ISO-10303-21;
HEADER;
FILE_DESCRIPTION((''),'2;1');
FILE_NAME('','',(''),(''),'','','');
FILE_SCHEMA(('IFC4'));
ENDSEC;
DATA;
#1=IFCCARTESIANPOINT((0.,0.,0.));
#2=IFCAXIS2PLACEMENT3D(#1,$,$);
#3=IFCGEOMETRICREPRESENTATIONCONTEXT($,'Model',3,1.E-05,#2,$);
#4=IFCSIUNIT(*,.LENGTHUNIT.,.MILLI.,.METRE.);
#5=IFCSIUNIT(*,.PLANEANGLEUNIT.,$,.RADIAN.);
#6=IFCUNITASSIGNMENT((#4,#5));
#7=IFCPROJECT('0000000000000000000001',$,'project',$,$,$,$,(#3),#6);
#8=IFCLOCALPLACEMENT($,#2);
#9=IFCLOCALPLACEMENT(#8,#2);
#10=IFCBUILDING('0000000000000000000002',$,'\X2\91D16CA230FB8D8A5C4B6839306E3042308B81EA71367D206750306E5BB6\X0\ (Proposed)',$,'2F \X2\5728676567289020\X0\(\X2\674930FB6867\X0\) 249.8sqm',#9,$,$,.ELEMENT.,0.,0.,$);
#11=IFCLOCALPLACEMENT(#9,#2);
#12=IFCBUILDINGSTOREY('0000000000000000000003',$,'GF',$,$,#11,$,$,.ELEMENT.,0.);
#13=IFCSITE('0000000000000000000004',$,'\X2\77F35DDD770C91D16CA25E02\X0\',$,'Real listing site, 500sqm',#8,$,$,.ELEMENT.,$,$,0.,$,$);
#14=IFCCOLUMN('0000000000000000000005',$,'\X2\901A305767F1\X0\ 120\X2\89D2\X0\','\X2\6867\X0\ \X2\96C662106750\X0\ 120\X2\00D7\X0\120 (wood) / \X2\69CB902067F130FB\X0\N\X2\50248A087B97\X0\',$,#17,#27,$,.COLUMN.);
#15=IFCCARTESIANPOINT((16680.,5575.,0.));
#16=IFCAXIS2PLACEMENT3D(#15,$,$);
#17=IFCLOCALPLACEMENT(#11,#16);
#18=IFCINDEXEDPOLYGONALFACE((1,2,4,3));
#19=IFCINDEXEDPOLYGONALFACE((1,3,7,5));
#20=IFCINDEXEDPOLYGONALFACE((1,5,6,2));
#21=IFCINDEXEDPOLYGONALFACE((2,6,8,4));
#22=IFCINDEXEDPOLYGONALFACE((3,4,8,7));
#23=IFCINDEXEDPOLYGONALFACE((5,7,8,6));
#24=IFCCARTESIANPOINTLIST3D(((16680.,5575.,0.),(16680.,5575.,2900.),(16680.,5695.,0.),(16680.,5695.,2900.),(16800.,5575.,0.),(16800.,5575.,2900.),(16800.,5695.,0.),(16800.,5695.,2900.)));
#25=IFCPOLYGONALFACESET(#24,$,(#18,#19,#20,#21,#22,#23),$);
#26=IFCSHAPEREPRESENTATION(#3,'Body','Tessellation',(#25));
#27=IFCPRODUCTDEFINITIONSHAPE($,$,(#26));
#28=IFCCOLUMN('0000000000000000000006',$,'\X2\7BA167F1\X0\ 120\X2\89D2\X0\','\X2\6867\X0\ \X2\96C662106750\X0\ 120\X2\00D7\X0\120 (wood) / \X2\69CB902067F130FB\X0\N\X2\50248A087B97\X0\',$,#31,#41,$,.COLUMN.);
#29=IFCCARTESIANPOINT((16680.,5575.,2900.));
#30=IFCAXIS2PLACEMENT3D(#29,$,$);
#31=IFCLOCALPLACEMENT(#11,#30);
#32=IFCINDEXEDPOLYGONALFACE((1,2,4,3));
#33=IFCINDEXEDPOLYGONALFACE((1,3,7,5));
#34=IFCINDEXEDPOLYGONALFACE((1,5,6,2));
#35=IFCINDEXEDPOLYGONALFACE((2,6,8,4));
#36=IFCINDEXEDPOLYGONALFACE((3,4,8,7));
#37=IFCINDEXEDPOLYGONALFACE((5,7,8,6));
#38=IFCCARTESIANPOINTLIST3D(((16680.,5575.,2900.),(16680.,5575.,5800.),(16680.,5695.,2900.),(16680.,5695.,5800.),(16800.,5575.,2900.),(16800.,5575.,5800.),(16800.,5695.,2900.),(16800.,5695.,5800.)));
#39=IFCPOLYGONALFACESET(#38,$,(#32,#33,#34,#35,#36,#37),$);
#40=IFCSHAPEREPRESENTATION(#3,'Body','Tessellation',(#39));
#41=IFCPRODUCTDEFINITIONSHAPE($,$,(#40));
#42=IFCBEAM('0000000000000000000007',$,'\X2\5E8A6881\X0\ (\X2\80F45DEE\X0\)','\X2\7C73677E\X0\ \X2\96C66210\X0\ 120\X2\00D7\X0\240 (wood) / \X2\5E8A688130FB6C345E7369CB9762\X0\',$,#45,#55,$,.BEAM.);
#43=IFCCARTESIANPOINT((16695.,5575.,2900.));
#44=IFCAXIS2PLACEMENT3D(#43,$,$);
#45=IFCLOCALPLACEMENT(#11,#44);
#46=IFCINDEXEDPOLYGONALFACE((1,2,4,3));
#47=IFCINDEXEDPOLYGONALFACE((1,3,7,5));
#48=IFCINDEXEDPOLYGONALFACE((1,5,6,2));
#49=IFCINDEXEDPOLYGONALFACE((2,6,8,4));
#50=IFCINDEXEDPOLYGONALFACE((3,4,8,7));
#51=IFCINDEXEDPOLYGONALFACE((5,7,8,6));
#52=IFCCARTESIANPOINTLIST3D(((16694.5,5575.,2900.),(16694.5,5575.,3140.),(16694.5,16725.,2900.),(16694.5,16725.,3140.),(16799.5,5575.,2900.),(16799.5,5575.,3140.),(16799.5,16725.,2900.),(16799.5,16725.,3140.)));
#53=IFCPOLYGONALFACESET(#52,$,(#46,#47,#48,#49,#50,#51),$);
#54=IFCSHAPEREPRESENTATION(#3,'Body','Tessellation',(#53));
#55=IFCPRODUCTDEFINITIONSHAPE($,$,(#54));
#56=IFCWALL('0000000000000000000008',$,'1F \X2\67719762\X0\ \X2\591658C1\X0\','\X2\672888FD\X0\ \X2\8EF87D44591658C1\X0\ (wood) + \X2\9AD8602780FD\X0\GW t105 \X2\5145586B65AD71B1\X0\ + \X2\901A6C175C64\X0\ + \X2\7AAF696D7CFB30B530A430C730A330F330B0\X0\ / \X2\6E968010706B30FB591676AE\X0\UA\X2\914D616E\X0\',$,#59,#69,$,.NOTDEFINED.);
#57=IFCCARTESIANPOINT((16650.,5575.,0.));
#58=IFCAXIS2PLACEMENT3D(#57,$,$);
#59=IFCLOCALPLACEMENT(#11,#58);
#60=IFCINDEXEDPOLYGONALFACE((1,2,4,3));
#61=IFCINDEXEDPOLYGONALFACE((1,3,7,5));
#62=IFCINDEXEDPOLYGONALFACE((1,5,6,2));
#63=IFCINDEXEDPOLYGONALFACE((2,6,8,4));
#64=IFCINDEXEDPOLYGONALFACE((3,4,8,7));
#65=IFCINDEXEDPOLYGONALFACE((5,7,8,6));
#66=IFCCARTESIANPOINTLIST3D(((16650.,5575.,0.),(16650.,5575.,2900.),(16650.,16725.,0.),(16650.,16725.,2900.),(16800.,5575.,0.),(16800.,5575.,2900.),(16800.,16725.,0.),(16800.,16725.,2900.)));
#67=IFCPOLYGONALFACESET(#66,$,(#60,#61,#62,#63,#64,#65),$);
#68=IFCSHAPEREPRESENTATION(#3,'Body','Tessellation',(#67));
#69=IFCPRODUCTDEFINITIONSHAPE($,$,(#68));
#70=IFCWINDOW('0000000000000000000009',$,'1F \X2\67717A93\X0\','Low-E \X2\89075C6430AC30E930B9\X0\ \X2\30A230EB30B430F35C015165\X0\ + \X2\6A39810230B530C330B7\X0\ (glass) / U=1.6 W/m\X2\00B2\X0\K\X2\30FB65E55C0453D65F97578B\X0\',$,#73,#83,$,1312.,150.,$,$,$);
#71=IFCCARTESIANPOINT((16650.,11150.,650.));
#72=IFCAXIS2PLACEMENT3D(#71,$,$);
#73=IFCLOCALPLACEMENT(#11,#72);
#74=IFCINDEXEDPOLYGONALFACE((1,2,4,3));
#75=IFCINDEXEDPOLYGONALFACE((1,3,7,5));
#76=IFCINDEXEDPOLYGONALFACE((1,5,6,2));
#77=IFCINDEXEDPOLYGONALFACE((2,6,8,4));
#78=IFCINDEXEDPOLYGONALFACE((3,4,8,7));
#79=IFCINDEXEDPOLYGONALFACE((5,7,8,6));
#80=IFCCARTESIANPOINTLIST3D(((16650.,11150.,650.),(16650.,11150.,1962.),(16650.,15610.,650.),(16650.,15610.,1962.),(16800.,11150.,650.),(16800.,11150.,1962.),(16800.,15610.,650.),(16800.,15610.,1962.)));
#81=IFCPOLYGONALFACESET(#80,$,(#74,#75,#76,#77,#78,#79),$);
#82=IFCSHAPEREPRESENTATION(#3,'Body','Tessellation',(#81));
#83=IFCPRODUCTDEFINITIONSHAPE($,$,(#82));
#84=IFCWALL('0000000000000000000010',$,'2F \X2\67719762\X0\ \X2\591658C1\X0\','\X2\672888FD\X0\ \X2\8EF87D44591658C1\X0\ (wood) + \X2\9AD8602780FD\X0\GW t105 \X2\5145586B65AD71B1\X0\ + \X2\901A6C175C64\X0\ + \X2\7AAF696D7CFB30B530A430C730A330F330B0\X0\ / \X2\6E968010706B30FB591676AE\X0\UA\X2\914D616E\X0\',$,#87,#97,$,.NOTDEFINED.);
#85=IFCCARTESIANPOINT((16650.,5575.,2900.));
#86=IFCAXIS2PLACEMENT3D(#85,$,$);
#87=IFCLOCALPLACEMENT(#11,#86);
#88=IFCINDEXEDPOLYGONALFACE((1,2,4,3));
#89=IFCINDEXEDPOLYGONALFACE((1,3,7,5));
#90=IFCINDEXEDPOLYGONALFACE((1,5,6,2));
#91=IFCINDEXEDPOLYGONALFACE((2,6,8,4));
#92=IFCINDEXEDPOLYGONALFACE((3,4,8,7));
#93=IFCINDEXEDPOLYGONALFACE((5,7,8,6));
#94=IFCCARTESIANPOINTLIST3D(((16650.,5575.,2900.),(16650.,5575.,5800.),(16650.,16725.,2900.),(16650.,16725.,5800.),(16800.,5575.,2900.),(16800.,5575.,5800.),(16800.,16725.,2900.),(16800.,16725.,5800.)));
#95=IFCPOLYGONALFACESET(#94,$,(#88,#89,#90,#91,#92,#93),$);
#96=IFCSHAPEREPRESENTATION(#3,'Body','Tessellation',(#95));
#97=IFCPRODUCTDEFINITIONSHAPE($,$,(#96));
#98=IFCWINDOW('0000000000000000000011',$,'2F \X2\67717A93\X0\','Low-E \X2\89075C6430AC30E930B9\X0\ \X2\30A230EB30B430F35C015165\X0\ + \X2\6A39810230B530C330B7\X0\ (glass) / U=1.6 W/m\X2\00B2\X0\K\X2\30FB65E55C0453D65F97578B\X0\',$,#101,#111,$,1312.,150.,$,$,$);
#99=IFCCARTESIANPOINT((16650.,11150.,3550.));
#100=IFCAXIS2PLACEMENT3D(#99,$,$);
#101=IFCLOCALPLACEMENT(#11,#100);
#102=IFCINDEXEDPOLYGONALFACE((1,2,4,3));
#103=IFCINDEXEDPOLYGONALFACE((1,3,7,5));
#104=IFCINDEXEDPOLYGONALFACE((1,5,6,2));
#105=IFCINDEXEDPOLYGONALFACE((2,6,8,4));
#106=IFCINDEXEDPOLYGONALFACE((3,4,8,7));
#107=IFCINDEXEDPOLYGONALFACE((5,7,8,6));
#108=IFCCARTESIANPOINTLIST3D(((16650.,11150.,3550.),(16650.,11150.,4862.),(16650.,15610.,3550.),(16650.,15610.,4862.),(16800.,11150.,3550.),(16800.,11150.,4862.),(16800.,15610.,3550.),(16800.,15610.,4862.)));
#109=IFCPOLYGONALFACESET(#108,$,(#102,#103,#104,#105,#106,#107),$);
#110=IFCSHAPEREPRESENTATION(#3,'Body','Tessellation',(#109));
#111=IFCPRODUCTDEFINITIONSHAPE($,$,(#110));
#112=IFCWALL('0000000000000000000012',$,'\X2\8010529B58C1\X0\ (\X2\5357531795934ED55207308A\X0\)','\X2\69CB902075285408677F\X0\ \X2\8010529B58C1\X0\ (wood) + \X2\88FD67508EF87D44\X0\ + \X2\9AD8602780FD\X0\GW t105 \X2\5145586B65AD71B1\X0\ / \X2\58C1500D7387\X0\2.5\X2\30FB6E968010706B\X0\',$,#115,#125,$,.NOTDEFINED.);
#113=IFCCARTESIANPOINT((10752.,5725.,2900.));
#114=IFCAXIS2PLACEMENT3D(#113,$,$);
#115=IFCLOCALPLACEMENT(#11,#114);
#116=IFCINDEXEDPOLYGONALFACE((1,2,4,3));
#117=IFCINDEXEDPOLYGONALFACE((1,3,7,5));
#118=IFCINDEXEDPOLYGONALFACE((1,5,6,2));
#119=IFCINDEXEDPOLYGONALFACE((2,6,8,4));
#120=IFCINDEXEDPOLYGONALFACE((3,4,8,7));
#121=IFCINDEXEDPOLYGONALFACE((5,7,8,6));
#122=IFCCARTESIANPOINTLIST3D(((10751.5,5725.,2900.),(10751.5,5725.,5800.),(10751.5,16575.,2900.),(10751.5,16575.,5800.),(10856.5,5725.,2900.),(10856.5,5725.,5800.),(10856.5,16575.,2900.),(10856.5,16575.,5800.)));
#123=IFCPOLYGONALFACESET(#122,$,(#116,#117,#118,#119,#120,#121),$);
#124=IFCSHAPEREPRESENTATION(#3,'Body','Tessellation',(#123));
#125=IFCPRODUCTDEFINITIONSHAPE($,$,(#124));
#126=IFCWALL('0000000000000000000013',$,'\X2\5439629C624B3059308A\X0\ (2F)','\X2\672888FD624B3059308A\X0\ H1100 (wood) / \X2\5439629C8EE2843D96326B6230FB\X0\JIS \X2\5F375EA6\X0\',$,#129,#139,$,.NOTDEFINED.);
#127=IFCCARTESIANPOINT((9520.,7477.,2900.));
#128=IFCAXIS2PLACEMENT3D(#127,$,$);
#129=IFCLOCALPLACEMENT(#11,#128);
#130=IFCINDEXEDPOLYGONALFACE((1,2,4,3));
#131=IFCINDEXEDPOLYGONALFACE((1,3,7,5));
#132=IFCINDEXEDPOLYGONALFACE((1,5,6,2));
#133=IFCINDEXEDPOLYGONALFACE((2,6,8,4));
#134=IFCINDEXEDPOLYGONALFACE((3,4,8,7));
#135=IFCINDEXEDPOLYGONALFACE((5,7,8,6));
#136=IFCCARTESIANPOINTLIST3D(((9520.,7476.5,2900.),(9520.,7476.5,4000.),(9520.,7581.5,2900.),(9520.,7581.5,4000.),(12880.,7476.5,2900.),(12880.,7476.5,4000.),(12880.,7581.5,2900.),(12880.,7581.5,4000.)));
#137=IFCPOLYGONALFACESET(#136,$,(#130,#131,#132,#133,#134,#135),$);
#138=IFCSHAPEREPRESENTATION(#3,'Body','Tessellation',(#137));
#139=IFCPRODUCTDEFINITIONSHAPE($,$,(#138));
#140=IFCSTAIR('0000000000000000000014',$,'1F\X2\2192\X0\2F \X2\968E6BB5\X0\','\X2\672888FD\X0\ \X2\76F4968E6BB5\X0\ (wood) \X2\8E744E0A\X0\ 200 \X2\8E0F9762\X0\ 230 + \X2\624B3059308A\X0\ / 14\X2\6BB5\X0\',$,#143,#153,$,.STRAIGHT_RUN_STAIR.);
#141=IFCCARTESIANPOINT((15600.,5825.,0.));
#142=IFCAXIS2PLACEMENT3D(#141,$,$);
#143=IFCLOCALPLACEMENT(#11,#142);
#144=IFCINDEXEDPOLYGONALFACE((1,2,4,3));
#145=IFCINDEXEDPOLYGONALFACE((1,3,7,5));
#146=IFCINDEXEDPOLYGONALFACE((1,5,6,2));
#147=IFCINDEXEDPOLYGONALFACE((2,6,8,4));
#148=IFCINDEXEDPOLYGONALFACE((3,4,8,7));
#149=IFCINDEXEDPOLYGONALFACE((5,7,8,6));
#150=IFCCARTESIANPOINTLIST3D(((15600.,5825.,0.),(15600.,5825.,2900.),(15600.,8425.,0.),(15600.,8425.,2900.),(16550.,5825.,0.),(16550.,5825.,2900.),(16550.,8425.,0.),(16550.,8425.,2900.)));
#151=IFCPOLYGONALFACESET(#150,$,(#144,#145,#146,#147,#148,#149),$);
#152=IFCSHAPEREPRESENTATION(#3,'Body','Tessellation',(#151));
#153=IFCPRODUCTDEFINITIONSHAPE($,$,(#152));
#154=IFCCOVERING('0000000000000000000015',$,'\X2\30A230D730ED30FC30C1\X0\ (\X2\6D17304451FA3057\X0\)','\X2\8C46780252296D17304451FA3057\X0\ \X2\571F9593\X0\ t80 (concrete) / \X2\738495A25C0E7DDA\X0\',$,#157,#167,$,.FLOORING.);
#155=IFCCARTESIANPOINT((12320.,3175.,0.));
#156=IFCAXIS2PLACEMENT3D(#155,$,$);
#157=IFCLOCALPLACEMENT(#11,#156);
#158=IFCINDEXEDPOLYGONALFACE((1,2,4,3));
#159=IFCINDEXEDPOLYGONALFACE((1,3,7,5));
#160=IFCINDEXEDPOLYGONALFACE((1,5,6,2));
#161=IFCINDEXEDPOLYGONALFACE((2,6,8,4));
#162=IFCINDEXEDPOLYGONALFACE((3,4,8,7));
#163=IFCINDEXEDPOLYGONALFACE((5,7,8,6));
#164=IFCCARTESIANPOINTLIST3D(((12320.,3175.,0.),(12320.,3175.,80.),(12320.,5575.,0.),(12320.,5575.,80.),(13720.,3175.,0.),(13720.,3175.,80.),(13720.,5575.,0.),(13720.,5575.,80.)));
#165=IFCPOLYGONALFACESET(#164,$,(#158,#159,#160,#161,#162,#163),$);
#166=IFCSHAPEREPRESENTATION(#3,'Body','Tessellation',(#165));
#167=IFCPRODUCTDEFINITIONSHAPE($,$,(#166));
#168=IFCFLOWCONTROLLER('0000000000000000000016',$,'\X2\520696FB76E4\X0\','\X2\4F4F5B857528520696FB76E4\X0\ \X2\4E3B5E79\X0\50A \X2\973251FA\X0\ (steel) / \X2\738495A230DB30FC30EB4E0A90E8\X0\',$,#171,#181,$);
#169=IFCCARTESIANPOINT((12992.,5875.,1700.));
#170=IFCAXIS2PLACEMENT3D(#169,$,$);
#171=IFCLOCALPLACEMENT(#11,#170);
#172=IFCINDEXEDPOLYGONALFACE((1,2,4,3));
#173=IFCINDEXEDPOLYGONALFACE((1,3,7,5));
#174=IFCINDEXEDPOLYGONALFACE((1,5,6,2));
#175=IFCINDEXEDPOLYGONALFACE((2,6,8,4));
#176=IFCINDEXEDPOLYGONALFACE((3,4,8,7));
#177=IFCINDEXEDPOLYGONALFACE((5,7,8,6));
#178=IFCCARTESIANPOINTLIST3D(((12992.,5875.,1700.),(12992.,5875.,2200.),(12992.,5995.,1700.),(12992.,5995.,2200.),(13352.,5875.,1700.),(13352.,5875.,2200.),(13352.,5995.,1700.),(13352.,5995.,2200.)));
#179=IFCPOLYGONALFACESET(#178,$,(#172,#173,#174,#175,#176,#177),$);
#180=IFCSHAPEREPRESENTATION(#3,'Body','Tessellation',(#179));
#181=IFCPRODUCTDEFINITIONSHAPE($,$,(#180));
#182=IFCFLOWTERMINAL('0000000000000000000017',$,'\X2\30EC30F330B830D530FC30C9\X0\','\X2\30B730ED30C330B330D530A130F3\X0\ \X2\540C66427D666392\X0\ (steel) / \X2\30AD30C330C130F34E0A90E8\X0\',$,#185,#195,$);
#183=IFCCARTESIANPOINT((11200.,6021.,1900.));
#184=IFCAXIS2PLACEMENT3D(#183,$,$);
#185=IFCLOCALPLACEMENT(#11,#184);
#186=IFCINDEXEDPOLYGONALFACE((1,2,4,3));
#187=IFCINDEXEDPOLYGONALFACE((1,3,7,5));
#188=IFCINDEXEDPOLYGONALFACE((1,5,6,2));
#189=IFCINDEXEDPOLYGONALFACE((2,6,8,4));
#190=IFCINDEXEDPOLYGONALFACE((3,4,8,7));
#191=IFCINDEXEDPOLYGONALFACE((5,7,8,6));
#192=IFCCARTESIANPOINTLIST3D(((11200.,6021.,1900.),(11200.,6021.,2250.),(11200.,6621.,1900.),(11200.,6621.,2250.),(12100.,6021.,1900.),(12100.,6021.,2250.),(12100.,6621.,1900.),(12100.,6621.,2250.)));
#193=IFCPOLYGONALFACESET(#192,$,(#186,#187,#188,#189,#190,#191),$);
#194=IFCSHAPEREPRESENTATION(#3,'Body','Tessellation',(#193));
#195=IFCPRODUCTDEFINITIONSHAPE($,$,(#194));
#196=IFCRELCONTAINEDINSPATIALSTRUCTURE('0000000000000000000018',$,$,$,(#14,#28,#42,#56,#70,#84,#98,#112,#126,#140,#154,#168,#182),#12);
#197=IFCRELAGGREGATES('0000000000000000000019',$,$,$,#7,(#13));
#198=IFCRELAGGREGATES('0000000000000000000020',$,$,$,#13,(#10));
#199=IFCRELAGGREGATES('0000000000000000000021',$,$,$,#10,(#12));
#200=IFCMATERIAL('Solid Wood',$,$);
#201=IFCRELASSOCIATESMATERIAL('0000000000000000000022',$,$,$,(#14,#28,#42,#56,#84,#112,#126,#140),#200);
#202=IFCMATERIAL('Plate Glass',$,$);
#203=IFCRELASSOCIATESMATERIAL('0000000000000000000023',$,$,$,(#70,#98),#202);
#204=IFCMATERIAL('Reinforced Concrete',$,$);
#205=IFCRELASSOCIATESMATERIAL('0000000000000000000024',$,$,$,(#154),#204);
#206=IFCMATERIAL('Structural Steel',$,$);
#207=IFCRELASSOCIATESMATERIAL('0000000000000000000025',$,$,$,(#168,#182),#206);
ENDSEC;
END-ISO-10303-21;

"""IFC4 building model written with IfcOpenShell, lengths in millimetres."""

from ifc_helpers import new_model, si_unit, frame, frame_2d, origin, place, context, project, spatial, rectangle, extrude, material, element, fill, save


model = new_model("IFC4")

# Units and contexts
model_context = context("Model", 3, precision=1e-05, world=origin())
ifc_project = project(units=[si_unit("LENGTHUNIT", "METRE", prefix="MILLI"), si_unit("PLANEANGLEUNIT", "RADIAN")], contexts=[model_context])

# Site, building, storey
site_placement = place(None, origin())
site = spatial("IfcSite", under=ifc_project, at=site_placement, Name="石川県金沢市", ObjectType="Real listing site, 500sqm", CompositionType="ELEMENT", RefElevation=0.0)
building_placement = place(site_placement, origin())
building = spatial("IfcBuilding", under=site, at=building_placement, Name="金沢・越屋根のある自然素材の家 (Proposed)", ObjectType="2F 在来木造(杉・桧) 249.8sqm", CompositionType="ELEMENT", ElevationOfRefHeight=0.0, ElevationOfTerrain=0.0)
storey_placement = place(building_placement, origin())
storey = spatial("IfcBuildingStorey", under=building, at=storey_placement, Name="GF", CompositionType="ELEMENT", Elevation=0.0)

# Columns
ifc_material_1 = material(Name="Solid Wood")
column_1_placement = place(storey_placement, frame((16680.0, 5575.0, 0.0)))
element("IfcColumn", 1, at=column_1_placement, inside=storey, material=ifc_material_1, Name="通し柱 120角", Description="桧 集成材 120×120 (wood) / 構造柱・N値計算", PredefinedType="COLUMN", context=model_context, shape_type="SweptSolid", body=[
    extrude(rectangle(XDim=120.0, YDim=120.0, at=frame_2d((60.0, 60.0))), frame((16680.0, 5575.0, 0.0)), (0.0, 0.0, 1.0), 2900.0),
])
column_2_placement = place(storey_placement, frame((16680.0, 5575.0, 2900.0)))
element("IfcColumn", 2, at=column_2_placement, inside=storey, material=ifc_material_1, Name="管柱 120角", Description="桧 集成材 120×120 (wood) / 構造柱・N値計算", PredefinedType="COLUMN", context=model_context, shape_type="SweptSolid", body=[
    extrude(rectangle(XDim=120.0, YDim=120.0, at=frame_2d((60.0, 60.0))), frame((16680.0, 5575.0, 2900.0)), (0.0, 0.0, 1.0), 2900.0),
])

# Beam
beam_1_placement = place(storey_placement, frame((16695.0, 5575.0, 2900.0)))
element("IfcBeam", 3, at=beam_1_placement, inside=storey, material=ifc_material_1, Name="床梁 (胴差)", Description="米松 集成 120×240 (wood) / 床梁・水平構面", PredefinedType="BEAM", context=model_context, shape_type="SweptSolid", body=[
    extrude(rectangle(XDim=105.0, YDim=11150.0, at=frame_2d((52.0, 5575.0))), frame((16695.0, 5575.0, 2900.0)), (0.0, 0.0, 1.0), 240.0),
])

# Wall, opening, window
wall_1_placement = place(storey_placement, frame((16650.0, 5575.0, 0.0)))
wall_1 = element("IfcWall", 4, at=wall_1_placement, inside=storey, material=ifc_material_1, Name="1F 東面 外壁", Description="木製 軸組外壁 (wood) + 高性能GW t105 充填断熱 + 通気層 + 窯業系サイディング / 準耐火・外皮UA配慮", PredefinedType="NOTDEFINED", context=model_context, shape_type="SweptSolid", body=[
    extrude(rectangle(XDim=150.0, YDim=11150.0, at=frame_2d((75.0, 5575.0))), frame((16650.0, 5575.0, 0.0)), (0.0, 0.0, 1.0), 2900.0),
])
opening_1_placement = place(storey_placement, frame((16650.0, 11150.0, 650.0)))
opening_1 = element("IfcOpeningElement", 5, at=opening_1_placement, cuts=wall_1, PredefinedType="NOTDEFINED", context=model_context, shape_type="SweptSolid", body=[
    extrude(rectangle(XDim=150.0, YDim=4460.0, at=frame_2d((75.0, 2230.0))), frame((16650.0, 11150.0, 650.0)), (0.0, 0.0, 1.0), 1312.0),
])
ifc_material_2 = material(Name="Plate Glass")
window_1_placement = place(storey_placement, frame((16650.0, 11150.0, 650.0)))
window_1 = element("IfcWindow", 6, at=window_1_placement, inside=storey, material=ifc_material_2, Name="1F 東窓", Description="Low-E 複層ガラス アルゴン封入 + 樹脂サッシ (glass) / U=1.6 W/m²K・日射取得型", OverallHeight=1312.0, OverallWidth=150.0, context=model_context, shape_type="SweptSolid", body=[
    extrude(rectangle(XDim=150.0, YDim=4460.0, at=frame_2d((75.0, 2230.0))), frame((16650.0, 11150.0, 650.0)), (0.0, 0.0, 1.0), 1312.0),
])
fill(opening_1, window_1)

# Wall, opening, window
wall_2_placement = place(storey_placement, frame((16650.0, 5575.0, 2900.0)))
wall_2 = element("IfcWall", 7, at=wall_2_placement, inside=storey, material=ifc_material_1, Name="2F 東面 外壁", Description="木製 軸組外壁 (wood) + 高性能GW t105 充填断熱 + 通気層 + 窯業系サイディング / 準耐火・外皮UA配慮", PredefinedType="NOTDEFINED", context=model_context, shape_type="SweptSolid", body=[
    extrude(rectangle(XDim=150.0, YDim=11150.0, at=frame_2d((75.0, 5575.0))), frame((16650.0, 5575.0, 2900.0)), (0.0, 0.0, 1.0), 2900.0),
])
opening_2_placement = place(storey_placement, frame((16650.0, 11150.0, 3550.0)))
opening_2 = element("IfcOpeningElement", 8, at=opening_2_placement, cuts=wall_2, PredefinedType="NOTDEFINED", context=model_context, shape_type="SweptSolid", body=[
    extrude(rectangle(XDim=150.0, YDim=4460.0, at=frame_2d((75.0, 2230.0))), frame((16650.0, 11150.0, 3550.0)), (0.0, 0.0, 1.0), 1312.0),
])
window_2_placement = place(storey_placement, frame((16650.0, 11150.0, 3550.0)))
window_2 = element("IfcWindow", 9, at=window_2_placement, inside=storey, material=ifc_material_2, Name="2F 東窓", Description="Low-E 複層ガラス アルゴン封入 + 樹脂サッシ (glass) / U=1.6 W/m²K・日射取得型", OverallHeight=1312.0, OverallWidth=150.0, context=model_context, shape_type="SweptSolid", body=[
    extrude(rectangle(XDim=150.0, YDim=4460.0, at=frame_2d((75.0, 2230.0))), frame((16650.0, 11150.0, 3550.0)), (0.0, 0.0, 1.0), 1312.0),
])
fill(opening_2, window_2)

# Walls
wall_3_placement = place(storey_placement, frame((10752.0, 5725.0, 2900.0)))
element("IfcWall", 10, at=wall_3_placement, inside=storey, material=ifc_material_1, Name="耐力壁 (南北間仕切り)", Description="構造用合板 耐力壁 (wood) + 製材軸組 + 高性能GW t105 充填断熱 / 壁倍率2.5・準耐火", PredefinedType="NOTDEFINED", context=model_context, shape_type="SweptSolid", body=[
    extrude(rectangle(XDim=105.0, YDim=10850.0, at=frame_2d((52.0, 5425.0))), frame((10752.0, 5725.0, 2900.0)), (0.0, 0.0, 1.0), 2900.0),
])
wall_4_placement = place(storey_placement, frame((9520.0, 7477.0, 2900.0)))
element("IfcWall", 11, at=wall_4_placement, inside=storey, material=ifc_material_1, Name="吹抜手すり (2F)", Description="木製手すり H1100 (wood) / 吹抜転落防止・JIS 強度", PredefinedType="NOTDEFINED", context=model_context, shape_type="SweptSolid", body=[
    extrude(rectangle(XDim=3360.0, YDim=105.0, at=frame_2d((1680.0, 52.0))), frame((9520.0, 7477.0, 2900.0)), (0.0, 0.0, 1.0), 1100.0),
])

# Stair
stair_placement = place(storey_placement, frame((15600.0, 5825.0, 0.0)))
element("IfcStair", 12, at=stair_placement, inside=storey, material=ifc_material_1, Name="1F→2F 階段", Description="木製 直階段 (wood) 蹴上 200 踏面 230 + 手すり / 14段", PredefinedType="STRAIGHT_RUN_STAIR", context=model_context, shape_type="SweptSolid", body=[
    extrude(rectangle(XDim=950.0, YDim=2600.0, at=frame_2d((475.0, 1300.0))), frame((15600.0, 5825.0, 0.0)), (0.0, 0.0, 1.0), 2900.0),
])

# Covering
ifc_material_3 = material(Name="Reinforced Concrete")
covering_placement = place(storey_placement, frame((12320.0, 3175.0, 0.0)))
element("IfcCovering", 13, at=covering_placement, inside=storey, material=ifc_material_3, Name="アプローチ (洗い出し)", Description="豆砂利洗い出し 土間 t80 (concrete) / 玄関導線", PredefinedType="FLOORING", context=model_context, shape_type="SweptSolid", body=[
    extrude(rectangle(XDim=1400.0, YDim=2400.0, at=frame_2d((700.0, 1200.0))), frame((12320.0, 3175.0, 0.0)), (0.0, 0.0, 1.0), 80.0),
])

# Flow controller
ifc_material_4 = material(Name="Structural Steel")
flow_controller_placement = place(storey_placement, frame((12992.0, 5875.0, 1700.0)))
element("IfcFlowController", 14, at=flow_controller_placement, inside=storey, material=ifc_material_4, Name="分電盤", Description="住宅用分電盤 主幹50A 露出 (steel) / 玄関ホール上部", context=model_context, shape_type="SweptSolid", body=[
    extrude(rectangle(XDim=360.0, YDim=120.0, at=frame_2d((180.0, 60.0))), frame((12992.0, 5875.0, 1700.0)), (0.0, 0.0, 1.0), 500.0),
])

# Flow terminal
flow_terminal_1_placement = place(storey_placement, frame((11200.0, 6021.0, 1900.0)))
element("IfcFlowTerminal", 15, at=flow_terminal_1_placement, inside=storey, material=ifc_material_4, Name="レンジフード", Description="シロッコファン 同時給排 (steel) / キッチン上部", context=model_context, shape_type="SweptSolid", body=[
    extrude(rectangle(XDim=900.0, YDim=600.0, at=frame_2d((450.0, 300.0))), frame((11200.0, 6021.0, 1900.0)), (0.0, 0.0, 1.0), 350.0),
])

save(model, "model.ifc")
